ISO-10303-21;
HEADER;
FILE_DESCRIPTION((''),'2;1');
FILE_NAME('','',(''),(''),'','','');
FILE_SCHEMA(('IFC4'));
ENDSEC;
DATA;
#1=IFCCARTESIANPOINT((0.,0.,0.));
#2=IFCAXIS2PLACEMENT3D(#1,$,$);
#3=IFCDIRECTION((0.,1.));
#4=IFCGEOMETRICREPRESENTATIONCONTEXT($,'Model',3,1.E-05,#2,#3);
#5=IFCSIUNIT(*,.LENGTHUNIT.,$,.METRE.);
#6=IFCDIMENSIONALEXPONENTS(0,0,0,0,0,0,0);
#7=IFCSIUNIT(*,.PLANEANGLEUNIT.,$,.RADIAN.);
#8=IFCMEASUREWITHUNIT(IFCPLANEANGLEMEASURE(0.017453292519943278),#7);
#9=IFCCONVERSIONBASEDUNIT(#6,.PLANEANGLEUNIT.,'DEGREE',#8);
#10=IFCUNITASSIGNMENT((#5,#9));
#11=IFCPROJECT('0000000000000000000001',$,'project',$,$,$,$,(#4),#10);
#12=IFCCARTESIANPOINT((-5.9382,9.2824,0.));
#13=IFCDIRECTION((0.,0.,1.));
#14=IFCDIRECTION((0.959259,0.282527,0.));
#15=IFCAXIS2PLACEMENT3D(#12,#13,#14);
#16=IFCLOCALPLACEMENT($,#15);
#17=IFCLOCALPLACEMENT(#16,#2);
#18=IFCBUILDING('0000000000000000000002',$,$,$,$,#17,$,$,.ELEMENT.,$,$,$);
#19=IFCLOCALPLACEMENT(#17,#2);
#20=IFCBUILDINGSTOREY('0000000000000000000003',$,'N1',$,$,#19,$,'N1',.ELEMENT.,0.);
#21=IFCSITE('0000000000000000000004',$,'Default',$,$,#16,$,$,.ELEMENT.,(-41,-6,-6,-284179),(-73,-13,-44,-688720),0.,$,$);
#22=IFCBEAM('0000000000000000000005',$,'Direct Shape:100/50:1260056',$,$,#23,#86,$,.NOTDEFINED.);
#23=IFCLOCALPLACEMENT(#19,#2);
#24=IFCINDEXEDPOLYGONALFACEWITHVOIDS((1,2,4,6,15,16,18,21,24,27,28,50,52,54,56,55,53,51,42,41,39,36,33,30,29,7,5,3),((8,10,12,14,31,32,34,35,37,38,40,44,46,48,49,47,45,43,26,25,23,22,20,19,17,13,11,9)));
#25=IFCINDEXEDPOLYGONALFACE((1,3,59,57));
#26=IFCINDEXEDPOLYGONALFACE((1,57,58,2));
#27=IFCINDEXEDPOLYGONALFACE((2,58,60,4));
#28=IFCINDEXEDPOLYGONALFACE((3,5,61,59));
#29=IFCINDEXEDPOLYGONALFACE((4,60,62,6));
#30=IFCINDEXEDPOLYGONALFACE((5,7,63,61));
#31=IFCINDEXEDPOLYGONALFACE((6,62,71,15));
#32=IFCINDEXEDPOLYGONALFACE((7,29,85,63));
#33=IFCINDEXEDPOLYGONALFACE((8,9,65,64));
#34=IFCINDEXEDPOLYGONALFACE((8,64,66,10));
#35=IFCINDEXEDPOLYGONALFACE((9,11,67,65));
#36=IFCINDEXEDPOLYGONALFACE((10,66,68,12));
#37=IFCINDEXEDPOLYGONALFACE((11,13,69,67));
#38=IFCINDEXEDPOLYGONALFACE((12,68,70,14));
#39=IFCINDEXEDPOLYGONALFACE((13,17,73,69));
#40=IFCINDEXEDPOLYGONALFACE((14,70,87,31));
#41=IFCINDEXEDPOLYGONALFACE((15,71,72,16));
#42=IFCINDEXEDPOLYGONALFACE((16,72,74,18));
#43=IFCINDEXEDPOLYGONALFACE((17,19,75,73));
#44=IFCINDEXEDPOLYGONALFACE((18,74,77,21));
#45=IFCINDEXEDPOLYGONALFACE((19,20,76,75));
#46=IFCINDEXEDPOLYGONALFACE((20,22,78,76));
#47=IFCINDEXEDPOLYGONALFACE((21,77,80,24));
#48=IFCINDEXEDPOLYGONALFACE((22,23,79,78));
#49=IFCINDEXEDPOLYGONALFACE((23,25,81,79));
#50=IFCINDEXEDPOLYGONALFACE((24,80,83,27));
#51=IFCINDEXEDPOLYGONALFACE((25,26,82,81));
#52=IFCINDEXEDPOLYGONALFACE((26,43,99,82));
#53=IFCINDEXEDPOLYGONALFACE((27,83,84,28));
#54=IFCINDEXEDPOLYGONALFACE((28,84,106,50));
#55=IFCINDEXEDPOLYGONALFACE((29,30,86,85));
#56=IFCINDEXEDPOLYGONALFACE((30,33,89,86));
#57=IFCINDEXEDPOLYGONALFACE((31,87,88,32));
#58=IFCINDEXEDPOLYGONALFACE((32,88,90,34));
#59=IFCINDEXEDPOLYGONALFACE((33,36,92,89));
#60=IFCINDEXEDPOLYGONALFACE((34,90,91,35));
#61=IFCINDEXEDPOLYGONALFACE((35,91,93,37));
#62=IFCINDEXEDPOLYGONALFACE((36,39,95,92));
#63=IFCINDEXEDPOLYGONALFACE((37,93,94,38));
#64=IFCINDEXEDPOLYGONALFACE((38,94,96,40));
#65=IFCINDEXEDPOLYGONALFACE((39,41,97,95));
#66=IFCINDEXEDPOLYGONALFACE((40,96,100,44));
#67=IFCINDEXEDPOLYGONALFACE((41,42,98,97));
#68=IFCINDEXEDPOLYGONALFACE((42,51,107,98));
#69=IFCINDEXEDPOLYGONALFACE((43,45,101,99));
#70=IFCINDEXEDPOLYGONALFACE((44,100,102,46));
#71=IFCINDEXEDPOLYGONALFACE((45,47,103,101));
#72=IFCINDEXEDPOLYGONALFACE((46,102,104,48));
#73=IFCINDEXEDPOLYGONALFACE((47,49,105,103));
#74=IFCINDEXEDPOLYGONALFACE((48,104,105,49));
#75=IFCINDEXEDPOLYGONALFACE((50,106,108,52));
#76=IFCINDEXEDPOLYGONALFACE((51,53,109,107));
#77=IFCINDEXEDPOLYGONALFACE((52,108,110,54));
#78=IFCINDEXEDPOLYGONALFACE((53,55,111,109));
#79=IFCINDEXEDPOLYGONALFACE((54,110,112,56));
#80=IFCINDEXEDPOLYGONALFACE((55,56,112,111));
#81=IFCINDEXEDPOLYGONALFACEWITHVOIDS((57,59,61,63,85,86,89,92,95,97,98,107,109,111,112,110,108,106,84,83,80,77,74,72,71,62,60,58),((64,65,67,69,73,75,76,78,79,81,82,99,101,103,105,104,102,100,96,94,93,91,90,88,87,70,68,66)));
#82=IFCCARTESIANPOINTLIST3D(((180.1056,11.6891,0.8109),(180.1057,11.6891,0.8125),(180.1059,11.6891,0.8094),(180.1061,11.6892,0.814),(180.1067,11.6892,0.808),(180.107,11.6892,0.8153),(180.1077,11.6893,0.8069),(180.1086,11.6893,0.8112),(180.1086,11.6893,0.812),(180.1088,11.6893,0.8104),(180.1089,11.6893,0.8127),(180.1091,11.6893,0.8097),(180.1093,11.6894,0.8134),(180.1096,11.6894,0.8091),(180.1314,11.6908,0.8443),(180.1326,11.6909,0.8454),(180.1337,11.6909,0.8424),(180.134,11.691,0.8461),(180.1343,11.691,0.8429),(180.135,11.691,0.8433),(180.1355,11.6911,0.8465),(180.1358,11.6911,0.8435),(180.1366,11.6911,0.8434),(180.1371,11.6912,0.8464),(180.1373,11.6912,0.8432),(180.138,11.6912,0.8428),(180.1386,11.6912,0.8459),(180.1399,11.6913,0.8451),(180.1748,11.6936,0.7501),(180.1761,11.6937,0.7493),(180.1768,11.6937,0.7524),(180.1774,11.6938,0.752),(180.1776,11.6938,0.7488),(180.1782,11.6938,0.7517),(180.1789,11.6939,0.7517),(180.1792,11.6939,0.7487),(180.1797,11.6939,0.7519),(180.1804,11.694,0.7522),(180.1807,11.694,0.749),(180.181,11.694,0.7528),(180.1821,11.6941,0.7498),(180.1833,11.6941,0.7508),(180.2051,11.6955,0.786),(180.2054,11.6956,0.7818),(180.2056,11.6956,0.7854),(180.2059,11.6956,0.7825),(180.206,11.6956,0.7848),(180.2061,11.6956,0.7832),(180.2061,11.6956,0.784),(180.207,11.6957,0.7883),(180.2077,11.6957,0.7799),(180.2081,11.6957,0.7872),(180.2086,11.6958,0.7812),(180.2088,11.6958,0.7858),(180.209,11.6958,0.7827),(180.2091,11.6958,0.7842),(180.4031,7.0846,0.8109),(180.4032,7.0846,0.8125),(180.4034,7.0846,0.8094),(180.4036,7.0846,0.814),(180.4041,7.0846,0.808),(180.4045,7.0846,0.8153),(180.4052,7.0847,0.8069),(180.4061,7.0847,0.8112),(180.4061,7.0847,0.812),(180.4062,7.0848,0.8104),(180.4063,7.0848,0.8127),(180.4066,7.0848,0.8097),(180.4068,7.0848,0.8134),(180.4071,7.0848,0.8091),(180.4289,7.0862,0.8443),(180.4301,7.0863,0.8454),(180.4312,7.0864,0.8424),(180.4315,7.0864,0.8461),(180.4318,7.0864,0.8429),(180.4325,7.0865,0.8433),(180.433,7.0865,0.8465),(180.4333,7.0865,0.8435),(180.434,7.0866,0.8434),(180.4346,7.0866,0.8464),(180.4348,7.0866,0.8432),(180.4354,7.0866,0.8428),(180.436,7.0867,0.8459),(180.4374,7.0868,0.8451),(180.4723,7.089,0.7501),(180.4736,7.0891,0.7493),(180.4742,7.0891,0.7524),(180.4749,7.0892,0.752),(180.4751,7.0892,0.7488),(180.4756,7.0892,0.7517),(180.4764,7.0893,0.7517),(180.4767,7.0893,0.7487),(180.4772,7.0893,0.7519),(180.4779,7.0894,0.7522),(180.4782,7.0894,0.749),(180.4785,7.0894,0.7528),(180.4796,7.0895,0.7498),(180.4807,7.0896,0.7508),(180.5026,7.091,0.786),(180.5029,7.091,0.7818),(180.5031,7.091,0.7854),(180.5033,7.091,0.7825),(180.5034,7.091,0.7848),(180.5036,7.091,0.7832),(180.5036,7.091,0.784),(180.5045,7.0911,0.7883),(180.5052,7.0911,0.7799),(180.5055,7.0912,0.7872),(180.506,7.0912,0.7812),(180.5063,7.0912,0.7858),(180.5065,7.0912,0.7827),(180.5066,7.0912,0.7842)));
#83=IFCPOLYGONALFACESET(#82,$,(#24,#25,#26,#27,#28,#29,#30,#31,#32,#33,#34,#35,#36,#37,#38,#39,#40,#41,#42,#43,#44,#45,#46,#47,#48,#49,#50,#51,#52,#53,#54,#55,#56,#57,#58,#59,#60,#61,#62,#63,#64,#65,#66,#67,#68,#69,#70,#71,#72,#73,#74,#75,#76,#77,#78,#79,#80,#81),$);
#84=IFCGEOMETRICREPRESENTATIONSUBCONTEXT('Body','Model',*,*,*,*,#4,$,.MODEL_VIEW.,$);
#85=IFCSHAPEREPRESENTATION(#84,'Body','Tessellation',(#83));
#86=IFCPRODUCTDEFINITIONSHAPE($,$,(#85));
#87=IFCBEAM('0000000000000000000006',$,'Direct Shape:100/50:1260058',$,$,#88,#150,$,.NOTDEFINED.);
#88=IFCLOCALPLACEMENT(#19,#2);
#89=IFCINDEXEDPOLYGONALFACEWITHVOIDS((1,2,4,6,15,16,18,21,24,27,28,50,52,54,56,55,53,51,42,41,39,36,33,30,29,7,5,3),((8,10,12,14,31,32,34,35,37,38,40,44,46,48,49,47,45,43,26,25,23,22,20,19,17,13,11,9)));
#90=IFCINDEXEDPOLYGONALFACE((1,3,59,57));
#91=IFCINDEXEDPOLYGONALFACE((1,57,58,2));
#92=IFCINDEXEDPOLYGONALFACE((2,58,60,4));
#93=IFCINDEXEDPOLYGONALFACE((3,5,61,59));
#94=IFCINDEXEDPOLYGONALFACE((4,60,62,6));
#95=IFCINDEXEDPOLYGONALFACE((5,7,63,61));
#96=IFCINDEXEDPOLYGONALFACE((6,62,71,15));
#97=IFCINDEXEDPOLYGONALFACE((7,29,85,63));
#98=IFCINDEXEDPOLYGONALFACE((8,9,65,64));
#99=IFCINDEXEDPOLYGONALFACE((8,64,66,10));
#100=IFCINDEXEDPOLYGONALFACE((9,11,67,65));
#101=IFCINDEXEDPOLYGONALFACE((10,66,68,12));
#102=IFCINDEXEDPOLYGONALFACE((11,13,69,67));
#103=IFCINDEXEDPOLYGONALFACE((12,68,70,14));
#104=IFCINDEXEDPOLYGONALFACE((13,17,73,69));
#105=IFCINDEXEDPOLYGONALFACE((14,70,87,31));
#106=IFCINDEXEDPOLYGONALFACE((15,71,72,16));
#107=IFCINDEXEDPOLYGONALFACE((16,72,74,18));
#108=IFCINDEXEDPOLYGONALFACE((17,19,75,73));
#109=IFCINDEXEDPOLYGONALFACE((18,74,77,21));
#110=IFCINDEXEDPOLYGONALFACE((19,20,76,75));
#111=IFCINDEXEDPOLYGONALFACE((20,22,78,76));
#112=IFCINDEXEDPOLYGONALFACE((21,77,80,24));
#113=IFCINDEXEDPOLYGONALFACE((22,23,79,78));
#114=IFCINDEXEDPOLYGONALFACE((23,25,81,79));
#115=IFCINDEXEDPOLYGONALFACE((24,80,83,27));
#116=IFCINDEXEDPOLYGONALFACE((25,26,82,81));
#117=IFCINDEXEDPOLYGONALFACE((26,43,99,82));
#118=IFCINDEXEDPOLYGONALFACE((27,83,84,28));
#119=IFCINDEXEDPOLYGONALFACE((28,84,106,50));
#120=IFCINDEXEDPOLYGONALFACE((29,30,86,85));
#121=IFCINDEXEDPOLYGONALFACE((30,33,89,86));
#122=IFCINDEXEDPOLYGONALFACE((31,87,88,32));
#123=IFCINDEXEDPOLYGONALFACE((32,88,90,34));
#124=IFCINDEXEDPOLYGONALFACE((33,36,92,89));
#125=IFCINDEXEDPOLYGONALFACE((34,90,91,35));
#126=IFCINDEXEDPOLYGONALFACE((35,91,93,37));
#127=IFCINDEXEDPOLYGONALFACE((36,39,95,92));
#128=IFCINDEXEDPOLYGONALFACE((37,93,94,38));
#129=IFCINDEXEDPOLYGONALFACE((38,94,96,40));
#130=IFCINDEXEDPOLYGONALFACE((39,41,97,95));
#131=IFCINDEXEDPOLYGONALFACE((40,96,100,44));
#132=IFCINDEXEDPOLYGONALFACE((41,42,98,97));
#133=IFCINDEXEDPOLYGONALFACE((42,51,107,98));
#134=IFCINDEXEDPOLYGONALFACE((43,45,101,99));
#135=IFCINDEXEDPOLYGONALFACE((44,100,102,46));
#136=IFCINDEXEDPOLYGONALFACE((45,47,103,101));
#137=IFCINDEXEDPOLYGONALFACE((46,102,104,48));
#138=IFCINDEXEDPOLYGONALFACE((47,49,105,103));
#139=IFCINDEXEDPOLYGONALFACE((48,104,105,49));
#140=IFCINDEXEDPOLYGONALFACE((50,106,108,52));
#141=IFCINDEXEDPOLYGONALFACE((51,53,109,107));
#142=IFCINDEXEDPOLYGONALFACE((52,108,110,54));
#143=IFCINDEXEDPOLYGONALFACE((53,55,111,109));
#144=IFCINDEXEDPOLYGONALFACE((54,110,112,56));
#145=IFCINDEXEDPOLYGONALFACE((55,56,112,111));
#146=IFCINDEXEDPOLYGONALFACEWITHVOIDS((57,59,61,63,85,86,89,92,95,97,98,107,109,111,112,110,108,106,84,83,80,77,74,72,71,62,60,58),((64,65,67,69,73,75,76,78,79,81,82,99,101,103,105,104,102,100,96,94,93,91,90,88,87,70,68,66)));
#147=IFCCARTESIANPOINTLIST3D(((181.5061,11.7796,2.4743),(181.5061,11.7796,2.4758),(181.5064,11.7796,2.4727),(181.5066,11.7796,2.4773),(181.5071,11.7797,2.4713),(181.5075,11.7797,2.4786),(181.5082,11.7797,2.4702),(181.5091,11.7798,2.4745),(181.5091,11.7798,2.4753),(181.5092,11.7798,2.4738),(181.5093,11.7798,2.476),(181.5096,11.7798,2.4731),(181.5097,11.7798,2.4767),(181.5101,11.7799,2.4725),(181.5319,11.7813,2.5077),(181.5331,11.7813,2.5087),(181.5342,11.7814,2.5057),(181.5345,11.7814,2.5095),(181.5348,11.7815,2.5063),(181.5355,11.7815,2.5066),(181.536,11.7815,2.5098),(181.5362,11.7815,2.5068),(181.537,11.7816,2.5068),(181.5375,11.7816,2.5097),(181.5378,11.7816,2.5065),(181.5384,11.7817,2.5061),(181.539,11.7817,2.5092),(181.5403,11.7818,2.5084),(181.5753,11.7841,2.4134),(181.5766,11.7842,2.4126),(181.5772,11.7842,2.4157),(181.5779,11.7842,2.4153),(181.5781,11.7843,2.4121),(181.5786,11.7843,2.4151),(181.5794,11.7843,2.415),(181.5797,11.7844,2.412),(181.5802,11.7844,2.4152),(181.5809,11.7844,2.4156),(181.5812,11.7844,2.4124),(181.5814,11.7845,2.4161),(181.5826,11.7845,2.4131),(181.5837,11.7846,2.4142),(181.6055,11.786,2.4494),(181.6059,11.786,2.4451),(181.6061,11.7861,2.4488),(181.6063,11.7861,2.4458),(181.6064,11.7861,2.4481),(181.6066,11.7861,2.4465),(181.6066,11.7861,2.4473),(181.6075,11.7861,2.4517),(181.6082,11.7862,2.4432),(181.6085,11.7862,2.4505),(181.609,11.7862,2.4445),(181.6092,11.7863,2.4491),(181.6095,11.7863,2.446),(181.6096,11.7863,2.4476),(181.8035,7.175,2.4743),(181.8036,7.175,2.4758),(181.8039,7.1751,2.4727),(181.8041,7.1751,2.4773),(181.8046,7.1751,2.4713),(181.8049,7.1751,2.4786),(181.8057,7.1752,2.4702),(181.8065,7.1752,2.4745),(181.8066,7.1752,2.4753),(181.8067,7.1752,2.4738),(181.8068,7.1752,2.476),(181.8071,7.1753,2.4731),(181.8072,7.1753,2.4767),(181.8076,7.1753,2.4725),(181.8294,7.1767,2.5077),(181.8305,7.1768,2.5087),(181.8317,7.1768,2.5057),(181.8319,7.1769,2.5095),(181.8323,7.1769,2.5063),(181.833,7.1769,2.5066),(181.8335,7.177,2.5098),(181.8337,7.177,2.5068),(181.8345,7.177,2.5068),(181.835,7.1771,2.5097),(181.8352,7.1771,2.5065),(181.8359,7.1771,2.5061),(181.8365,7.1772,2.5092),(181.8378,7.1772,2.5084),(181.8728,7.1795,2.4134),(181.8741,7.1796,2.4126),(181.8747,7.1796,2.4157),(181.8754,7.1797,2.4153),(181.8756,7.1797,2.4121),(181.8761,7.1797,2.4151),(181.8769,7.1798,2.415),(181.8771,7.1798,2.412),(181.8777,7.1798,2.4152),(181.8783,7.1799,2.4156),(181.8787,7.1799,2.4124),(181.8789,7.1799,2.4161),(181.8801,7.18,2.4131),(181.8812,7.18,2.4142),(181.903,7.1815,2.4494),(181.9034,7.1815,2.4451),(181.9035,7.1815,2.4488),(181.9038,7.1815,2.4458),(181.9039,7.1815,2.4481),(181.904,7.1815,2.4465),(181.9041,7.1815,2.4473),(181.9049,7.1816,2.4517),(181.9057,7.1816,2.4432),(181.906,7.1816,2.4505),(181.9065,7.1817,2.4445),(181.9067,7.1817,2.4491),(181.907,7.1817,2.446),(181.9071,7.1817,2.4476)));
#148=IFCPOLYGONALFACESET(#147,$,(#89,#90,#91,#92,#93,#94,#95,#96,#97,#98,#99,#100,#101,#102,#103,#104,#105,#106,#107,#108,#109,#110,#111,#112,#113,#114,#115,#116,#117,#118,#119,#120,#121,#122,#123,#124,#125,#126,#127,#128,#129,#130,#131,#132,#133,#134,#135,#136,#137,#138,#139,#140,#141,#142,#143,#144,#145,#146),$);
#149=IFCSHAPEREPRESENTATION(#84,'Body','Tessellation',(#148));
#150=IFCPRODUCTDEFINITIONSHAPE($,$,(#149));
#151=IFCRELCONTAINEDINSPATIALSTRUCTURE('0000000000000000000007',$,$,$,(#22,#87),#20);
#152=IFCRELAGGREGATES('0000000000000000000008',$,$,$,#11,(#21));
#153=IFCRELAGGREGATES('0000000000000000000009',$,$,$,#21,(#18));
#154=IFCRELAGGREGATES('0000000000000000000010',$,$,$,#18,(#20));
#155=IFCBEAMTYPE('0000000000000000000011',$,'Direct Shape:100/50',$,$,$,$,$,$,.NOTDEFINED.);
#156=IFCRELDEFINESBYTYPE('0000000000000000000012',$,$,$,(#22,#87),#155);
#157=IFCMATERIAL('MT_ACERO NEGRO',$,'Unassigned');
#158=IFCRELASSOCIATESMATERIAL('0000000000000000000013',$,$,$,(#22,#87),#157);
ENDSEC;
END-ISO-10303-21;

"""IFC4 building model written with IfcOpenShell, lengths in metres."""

from ifc_helpers import new_model, entity, si_unit, converted_unit, direction, frame, frame_2d, origin, place, context, subcontext, project, spatial, polyline, circle_curve, parameter, trimmed, segment, composite_curve, outline, extrude, material, type_object, element, save


model = new_model("IFC4")

# Units and contexts
model_context = context("Model", 3, precision=1e-05, world=origin(), true_north=direction((0.0, 1.0)))
body_context = subcontext(model_context, "Body", "Model", "MODEL_VIEW")
ifc_project = project(units=[si_unit("LENGTHUNIT", "METRE"), converted_unit("PLANEANGLEUNIT", "DEGREE", entity("IfcPlaneAngleMeasure", 0.017453292519943278), si_unit("PLANEANGLEUNIT", "RADIAN"), dimensions=[0, 0, 0, 0, 0, 0, 0])], contexts=[model_context])

# Site, building, storey
site_placement = place(None, frame((-5.9382, 9.2824, 0.0), z_axis=(0.0, 0.0, 1.0), x_axis=(0.959259, 0.282527, 0.0)))
site = spatial("IfcSite", under=ifc_project, at=site_placement, Name="Default", CompositionType="ELEMENT", RefLatitude=(-41, -6, -6, -284179), RefLongitude=(-73, -13, -44, -688720), RefElevation=0.0)
building_placement = place(site_placement, origin())
building = spatial("IfcBuilding", under=site, at=building_placement, CompositionType="ELEMENT")
storey_placement = place(building_placement, origin())
storey = spatial("IfcBuildingStorey", under=building, at=storey_placement, Name="N1", LongName="N1", CompositionType="ELEMENT", Elevation=0.0)

# Shared definitions
ifc_material_1 = material(Name="MT_ACERO NEGRO", Category="Unassigned")

# Beams
beam_type_1 = type_object("IfcBeamType", Name="Direct Shape:100/50", PredefinedType="NOTDEFINED")
beam_1_placement = place(storey_placement, origin())
element("IfcBeam", 1, at=beam_1_placement, inside=storey, type_object=beam_type_1, material=ifc_material_1, Name="Direct Shape:100/50:1260056", PredefinedType="NOTDEFINED", context=body_context, shape_type="SweptSolid", body=[
    extrude(outline(composite_curve([segment(trimmed(circle_curve(frame_2d((-0.019, -0.044), x_axis=(1.0, 0.0)), 0.006), [parameter(180.0)], [parameter(270.0)], True, "PARAMETER"), True, "CONTINUOUS"), segment(polyline([(-0.019, -0.05), (0.019, -0.05)]), True, "CONTINUOUS"), segment(trimmed(circle_curve(frame_2d((0.019, -0.044), x_axis=(1.0, 0.0)), 0.006), [parameter(270.0)], [parameter(0.0)], True, "PARAMETER"), True, "CONTINUOUS"), segment(polyline([(0.025, -0.044), (0.025, 0.044)]), True, "CONTINUOUS"), segment(trimmed(circle_curve(frame_2d((0.019, 0.044), x_axis=(1.0, 0.0)), 0.006), [parameter(360.0)], [parameter(90.0)], True, "PARAMETER"), True, "CONTINUOUS"), segment(polyline([(0.019, 0.05), (-0.019, 0.05)]), True, "CONTINUOUS"), segment(trimmed(circle_curve(frame_2d((-0.019, 0.044), x_axis=(1.0, 0.0)), 0.006), [parameter(90.0)], [parameter(180.0)], True, "PARAMETER"), True, "CONTINUOUS"), segment(polyline([(-0.025, 0.044), (-0.025, -0.044)]), True, "CONTINUOUS")], self_intersect=False), holes=[composite_curve([segment(polyline([(0.019, -0.047), (-0.019, -0.047)]), True, "CONTINUOUS"), segment(trimmed(circle_curve(frame_2d((-0.019, -0.044), x_axis=(1.0, 0.0)), 0.003), [parameter(180.0)], [parameter(270.0)], True, "PARAMETER"), False, "CONTINUOUS"), segment(polyline([(-0.022, -0.044), (-0.022, 0.044)]), True, "CONTINUOUS"), segment(trimmed(circle_curve(frame_2d((-0.019, 0.044), x_axis=(1.0, 0.0)), 0.003), [parameter(90.0)], [parameter(180.0)], True, "PARAMETER"), False, "CONTINUOUS"), segment(polyline([(-0.019, 0.047), (0.019, 0.047)]), True, "CONTINUOUS"), segment(trimmed(circle_curve(frame_2d((0.019, 0.044), x_axis=(1.0, 0.0)), 0.003), [parameter(0.0)], [parameter(90.0)], True, "PARAMETER"), False, "CONTINUOUS"), segment(polyline([(0.022, 0.044), (0.022, -0.044)]), True, "CONTINUOUS"), segment(trimmed(circle_curve(frame_2d((0.019, -0.044), x_axis=(1.0, 0.0)), 0.003), [parameter(270.0)], [parameter(0.0)], True, "PARAMETER"), False, "CONTINUOUS")], self_intersect=False)]), frame((180.4548, 7.0879, 0.7976), z_axis=(-0.064471, 0.99792, 0.0), x_axis=(0.643515, 0.041575, 0.764304)), (0.0, 0.0, 1.0), 4.6142),
])
beam_2_placement = place(storey_placement, origin())
element("IfcBeam", 2, at=beam_2_placement, inside=storey, type_object=beam_type_1, material=ifc_material_1, Name="Direct Shape:100/50:1260058", PredefinedType="NOTDEFINED", context=body_context, shape_type="SweptSolid", body=[
    extrude(outline(composite_curve([segment(trimmed(circle_curve(frame_2d((-0.019, -0.044), x_axis=(1.0, 0.0)), 0.006), [parameter(180.0)], [parameter(270.0)], True, "PARAMETER"), True, "CONTINUOUS"), segment(polyline([(-0.019, -0.05), (0.019, -0.05)]), True, "CONTINUOUS"), segment(trimmed(circle_curve(frame_2d((0.019, -0.044), x_axis=(1.0, 0.0)), 0.006), [parameter(270.0)], [parameter(0.0)], True, "PARAMETER"), True, "CONTINUOUS"), segment(polyline([(0.025, -0.044), (0.025, 0.044)]), True, "CONTINUOUS"), segment(trimmed(circle_curve(frame_2d((0.019, 0.044), x_axis=(1.0, 0.0)), 0.006), [parameter(360.0)], [parameter(90.0)], True, "PARAMETER"), True, "CONTINUOUS"), segment(polyline([(0.019, 0.05), (-0.019, 0.05)]), True, "CONTINUOUS"), segment(trimmed(circle_curve(frame_2d((-0.019, 0.044), x_axis=(1.0, 0.0)), 0.006), [parameter(90.0)], [parameter(180.0)], True, "PARAMETER"), True, "CONTINUOUS"), segment(polyline([(-0.025, 0.044), (-0.025, -0.044)]), True, "CONTINUOUS")], self_intersect=False), holes=[composite_curve([segment(polyline([(0.019, -0.047), (-0.019, -0.047)]), True, "CONTINUOUS"), segment(trimmed(circle_curve(frame_2d((-0.019, -0.044), x_axis=(1.0, 0.0)), 0.003), [parameter(180.0)], [parameter(270.0)], True, "PARAMETER"), False, "CONTINUOUS"), segment(polyline([(-0.022, -0.044), (-0.022, 0.044)]), True, "CONTINUOUS"), segment(trimmed(circle_curve(frame_2d((-0.019, 0.044), x_axis=(1.0, 0.0)), 0.003), [parameter(90.0)], [parameter(180.0)], True, "PARAMETER"), False, "CONTINUOUS"), segment(polyline([(-0.019, 0.047), (0.019, 0.047)]), True, "CONTINUOUS"), segment(trimmed(circle_curve(frame_2d((0.019, 0.044), x_axis=(1.0, 0.0)), 0.003), [parameter(0.0)], [parameter(90.0)], True, "PARAMETER"), False, "CONTINUOUS"), segment(polyline([(0.022, 0.044), (0.022, -0.044)]), True, "CONTINUOUS"), segment(trimmed(circle_curve(frame_2d((0.019, -0.044), x_axis=(1.0, 0.0)), 0.003), [parameter(270.0)], [parameter(0.0)], True, "PARAMETER"), False, "CONTINUOUS")], self_intersect=False)]), frame((181.8553, 7.1784, 2.4609), z_axis=(-0.064471, 0.99792, 0.0), x_axis=(0.643515, 0.041575, 0.764304)), (0.0, 0.0, 1.0), 4.6142),
])

save(model, "model.ifc")
